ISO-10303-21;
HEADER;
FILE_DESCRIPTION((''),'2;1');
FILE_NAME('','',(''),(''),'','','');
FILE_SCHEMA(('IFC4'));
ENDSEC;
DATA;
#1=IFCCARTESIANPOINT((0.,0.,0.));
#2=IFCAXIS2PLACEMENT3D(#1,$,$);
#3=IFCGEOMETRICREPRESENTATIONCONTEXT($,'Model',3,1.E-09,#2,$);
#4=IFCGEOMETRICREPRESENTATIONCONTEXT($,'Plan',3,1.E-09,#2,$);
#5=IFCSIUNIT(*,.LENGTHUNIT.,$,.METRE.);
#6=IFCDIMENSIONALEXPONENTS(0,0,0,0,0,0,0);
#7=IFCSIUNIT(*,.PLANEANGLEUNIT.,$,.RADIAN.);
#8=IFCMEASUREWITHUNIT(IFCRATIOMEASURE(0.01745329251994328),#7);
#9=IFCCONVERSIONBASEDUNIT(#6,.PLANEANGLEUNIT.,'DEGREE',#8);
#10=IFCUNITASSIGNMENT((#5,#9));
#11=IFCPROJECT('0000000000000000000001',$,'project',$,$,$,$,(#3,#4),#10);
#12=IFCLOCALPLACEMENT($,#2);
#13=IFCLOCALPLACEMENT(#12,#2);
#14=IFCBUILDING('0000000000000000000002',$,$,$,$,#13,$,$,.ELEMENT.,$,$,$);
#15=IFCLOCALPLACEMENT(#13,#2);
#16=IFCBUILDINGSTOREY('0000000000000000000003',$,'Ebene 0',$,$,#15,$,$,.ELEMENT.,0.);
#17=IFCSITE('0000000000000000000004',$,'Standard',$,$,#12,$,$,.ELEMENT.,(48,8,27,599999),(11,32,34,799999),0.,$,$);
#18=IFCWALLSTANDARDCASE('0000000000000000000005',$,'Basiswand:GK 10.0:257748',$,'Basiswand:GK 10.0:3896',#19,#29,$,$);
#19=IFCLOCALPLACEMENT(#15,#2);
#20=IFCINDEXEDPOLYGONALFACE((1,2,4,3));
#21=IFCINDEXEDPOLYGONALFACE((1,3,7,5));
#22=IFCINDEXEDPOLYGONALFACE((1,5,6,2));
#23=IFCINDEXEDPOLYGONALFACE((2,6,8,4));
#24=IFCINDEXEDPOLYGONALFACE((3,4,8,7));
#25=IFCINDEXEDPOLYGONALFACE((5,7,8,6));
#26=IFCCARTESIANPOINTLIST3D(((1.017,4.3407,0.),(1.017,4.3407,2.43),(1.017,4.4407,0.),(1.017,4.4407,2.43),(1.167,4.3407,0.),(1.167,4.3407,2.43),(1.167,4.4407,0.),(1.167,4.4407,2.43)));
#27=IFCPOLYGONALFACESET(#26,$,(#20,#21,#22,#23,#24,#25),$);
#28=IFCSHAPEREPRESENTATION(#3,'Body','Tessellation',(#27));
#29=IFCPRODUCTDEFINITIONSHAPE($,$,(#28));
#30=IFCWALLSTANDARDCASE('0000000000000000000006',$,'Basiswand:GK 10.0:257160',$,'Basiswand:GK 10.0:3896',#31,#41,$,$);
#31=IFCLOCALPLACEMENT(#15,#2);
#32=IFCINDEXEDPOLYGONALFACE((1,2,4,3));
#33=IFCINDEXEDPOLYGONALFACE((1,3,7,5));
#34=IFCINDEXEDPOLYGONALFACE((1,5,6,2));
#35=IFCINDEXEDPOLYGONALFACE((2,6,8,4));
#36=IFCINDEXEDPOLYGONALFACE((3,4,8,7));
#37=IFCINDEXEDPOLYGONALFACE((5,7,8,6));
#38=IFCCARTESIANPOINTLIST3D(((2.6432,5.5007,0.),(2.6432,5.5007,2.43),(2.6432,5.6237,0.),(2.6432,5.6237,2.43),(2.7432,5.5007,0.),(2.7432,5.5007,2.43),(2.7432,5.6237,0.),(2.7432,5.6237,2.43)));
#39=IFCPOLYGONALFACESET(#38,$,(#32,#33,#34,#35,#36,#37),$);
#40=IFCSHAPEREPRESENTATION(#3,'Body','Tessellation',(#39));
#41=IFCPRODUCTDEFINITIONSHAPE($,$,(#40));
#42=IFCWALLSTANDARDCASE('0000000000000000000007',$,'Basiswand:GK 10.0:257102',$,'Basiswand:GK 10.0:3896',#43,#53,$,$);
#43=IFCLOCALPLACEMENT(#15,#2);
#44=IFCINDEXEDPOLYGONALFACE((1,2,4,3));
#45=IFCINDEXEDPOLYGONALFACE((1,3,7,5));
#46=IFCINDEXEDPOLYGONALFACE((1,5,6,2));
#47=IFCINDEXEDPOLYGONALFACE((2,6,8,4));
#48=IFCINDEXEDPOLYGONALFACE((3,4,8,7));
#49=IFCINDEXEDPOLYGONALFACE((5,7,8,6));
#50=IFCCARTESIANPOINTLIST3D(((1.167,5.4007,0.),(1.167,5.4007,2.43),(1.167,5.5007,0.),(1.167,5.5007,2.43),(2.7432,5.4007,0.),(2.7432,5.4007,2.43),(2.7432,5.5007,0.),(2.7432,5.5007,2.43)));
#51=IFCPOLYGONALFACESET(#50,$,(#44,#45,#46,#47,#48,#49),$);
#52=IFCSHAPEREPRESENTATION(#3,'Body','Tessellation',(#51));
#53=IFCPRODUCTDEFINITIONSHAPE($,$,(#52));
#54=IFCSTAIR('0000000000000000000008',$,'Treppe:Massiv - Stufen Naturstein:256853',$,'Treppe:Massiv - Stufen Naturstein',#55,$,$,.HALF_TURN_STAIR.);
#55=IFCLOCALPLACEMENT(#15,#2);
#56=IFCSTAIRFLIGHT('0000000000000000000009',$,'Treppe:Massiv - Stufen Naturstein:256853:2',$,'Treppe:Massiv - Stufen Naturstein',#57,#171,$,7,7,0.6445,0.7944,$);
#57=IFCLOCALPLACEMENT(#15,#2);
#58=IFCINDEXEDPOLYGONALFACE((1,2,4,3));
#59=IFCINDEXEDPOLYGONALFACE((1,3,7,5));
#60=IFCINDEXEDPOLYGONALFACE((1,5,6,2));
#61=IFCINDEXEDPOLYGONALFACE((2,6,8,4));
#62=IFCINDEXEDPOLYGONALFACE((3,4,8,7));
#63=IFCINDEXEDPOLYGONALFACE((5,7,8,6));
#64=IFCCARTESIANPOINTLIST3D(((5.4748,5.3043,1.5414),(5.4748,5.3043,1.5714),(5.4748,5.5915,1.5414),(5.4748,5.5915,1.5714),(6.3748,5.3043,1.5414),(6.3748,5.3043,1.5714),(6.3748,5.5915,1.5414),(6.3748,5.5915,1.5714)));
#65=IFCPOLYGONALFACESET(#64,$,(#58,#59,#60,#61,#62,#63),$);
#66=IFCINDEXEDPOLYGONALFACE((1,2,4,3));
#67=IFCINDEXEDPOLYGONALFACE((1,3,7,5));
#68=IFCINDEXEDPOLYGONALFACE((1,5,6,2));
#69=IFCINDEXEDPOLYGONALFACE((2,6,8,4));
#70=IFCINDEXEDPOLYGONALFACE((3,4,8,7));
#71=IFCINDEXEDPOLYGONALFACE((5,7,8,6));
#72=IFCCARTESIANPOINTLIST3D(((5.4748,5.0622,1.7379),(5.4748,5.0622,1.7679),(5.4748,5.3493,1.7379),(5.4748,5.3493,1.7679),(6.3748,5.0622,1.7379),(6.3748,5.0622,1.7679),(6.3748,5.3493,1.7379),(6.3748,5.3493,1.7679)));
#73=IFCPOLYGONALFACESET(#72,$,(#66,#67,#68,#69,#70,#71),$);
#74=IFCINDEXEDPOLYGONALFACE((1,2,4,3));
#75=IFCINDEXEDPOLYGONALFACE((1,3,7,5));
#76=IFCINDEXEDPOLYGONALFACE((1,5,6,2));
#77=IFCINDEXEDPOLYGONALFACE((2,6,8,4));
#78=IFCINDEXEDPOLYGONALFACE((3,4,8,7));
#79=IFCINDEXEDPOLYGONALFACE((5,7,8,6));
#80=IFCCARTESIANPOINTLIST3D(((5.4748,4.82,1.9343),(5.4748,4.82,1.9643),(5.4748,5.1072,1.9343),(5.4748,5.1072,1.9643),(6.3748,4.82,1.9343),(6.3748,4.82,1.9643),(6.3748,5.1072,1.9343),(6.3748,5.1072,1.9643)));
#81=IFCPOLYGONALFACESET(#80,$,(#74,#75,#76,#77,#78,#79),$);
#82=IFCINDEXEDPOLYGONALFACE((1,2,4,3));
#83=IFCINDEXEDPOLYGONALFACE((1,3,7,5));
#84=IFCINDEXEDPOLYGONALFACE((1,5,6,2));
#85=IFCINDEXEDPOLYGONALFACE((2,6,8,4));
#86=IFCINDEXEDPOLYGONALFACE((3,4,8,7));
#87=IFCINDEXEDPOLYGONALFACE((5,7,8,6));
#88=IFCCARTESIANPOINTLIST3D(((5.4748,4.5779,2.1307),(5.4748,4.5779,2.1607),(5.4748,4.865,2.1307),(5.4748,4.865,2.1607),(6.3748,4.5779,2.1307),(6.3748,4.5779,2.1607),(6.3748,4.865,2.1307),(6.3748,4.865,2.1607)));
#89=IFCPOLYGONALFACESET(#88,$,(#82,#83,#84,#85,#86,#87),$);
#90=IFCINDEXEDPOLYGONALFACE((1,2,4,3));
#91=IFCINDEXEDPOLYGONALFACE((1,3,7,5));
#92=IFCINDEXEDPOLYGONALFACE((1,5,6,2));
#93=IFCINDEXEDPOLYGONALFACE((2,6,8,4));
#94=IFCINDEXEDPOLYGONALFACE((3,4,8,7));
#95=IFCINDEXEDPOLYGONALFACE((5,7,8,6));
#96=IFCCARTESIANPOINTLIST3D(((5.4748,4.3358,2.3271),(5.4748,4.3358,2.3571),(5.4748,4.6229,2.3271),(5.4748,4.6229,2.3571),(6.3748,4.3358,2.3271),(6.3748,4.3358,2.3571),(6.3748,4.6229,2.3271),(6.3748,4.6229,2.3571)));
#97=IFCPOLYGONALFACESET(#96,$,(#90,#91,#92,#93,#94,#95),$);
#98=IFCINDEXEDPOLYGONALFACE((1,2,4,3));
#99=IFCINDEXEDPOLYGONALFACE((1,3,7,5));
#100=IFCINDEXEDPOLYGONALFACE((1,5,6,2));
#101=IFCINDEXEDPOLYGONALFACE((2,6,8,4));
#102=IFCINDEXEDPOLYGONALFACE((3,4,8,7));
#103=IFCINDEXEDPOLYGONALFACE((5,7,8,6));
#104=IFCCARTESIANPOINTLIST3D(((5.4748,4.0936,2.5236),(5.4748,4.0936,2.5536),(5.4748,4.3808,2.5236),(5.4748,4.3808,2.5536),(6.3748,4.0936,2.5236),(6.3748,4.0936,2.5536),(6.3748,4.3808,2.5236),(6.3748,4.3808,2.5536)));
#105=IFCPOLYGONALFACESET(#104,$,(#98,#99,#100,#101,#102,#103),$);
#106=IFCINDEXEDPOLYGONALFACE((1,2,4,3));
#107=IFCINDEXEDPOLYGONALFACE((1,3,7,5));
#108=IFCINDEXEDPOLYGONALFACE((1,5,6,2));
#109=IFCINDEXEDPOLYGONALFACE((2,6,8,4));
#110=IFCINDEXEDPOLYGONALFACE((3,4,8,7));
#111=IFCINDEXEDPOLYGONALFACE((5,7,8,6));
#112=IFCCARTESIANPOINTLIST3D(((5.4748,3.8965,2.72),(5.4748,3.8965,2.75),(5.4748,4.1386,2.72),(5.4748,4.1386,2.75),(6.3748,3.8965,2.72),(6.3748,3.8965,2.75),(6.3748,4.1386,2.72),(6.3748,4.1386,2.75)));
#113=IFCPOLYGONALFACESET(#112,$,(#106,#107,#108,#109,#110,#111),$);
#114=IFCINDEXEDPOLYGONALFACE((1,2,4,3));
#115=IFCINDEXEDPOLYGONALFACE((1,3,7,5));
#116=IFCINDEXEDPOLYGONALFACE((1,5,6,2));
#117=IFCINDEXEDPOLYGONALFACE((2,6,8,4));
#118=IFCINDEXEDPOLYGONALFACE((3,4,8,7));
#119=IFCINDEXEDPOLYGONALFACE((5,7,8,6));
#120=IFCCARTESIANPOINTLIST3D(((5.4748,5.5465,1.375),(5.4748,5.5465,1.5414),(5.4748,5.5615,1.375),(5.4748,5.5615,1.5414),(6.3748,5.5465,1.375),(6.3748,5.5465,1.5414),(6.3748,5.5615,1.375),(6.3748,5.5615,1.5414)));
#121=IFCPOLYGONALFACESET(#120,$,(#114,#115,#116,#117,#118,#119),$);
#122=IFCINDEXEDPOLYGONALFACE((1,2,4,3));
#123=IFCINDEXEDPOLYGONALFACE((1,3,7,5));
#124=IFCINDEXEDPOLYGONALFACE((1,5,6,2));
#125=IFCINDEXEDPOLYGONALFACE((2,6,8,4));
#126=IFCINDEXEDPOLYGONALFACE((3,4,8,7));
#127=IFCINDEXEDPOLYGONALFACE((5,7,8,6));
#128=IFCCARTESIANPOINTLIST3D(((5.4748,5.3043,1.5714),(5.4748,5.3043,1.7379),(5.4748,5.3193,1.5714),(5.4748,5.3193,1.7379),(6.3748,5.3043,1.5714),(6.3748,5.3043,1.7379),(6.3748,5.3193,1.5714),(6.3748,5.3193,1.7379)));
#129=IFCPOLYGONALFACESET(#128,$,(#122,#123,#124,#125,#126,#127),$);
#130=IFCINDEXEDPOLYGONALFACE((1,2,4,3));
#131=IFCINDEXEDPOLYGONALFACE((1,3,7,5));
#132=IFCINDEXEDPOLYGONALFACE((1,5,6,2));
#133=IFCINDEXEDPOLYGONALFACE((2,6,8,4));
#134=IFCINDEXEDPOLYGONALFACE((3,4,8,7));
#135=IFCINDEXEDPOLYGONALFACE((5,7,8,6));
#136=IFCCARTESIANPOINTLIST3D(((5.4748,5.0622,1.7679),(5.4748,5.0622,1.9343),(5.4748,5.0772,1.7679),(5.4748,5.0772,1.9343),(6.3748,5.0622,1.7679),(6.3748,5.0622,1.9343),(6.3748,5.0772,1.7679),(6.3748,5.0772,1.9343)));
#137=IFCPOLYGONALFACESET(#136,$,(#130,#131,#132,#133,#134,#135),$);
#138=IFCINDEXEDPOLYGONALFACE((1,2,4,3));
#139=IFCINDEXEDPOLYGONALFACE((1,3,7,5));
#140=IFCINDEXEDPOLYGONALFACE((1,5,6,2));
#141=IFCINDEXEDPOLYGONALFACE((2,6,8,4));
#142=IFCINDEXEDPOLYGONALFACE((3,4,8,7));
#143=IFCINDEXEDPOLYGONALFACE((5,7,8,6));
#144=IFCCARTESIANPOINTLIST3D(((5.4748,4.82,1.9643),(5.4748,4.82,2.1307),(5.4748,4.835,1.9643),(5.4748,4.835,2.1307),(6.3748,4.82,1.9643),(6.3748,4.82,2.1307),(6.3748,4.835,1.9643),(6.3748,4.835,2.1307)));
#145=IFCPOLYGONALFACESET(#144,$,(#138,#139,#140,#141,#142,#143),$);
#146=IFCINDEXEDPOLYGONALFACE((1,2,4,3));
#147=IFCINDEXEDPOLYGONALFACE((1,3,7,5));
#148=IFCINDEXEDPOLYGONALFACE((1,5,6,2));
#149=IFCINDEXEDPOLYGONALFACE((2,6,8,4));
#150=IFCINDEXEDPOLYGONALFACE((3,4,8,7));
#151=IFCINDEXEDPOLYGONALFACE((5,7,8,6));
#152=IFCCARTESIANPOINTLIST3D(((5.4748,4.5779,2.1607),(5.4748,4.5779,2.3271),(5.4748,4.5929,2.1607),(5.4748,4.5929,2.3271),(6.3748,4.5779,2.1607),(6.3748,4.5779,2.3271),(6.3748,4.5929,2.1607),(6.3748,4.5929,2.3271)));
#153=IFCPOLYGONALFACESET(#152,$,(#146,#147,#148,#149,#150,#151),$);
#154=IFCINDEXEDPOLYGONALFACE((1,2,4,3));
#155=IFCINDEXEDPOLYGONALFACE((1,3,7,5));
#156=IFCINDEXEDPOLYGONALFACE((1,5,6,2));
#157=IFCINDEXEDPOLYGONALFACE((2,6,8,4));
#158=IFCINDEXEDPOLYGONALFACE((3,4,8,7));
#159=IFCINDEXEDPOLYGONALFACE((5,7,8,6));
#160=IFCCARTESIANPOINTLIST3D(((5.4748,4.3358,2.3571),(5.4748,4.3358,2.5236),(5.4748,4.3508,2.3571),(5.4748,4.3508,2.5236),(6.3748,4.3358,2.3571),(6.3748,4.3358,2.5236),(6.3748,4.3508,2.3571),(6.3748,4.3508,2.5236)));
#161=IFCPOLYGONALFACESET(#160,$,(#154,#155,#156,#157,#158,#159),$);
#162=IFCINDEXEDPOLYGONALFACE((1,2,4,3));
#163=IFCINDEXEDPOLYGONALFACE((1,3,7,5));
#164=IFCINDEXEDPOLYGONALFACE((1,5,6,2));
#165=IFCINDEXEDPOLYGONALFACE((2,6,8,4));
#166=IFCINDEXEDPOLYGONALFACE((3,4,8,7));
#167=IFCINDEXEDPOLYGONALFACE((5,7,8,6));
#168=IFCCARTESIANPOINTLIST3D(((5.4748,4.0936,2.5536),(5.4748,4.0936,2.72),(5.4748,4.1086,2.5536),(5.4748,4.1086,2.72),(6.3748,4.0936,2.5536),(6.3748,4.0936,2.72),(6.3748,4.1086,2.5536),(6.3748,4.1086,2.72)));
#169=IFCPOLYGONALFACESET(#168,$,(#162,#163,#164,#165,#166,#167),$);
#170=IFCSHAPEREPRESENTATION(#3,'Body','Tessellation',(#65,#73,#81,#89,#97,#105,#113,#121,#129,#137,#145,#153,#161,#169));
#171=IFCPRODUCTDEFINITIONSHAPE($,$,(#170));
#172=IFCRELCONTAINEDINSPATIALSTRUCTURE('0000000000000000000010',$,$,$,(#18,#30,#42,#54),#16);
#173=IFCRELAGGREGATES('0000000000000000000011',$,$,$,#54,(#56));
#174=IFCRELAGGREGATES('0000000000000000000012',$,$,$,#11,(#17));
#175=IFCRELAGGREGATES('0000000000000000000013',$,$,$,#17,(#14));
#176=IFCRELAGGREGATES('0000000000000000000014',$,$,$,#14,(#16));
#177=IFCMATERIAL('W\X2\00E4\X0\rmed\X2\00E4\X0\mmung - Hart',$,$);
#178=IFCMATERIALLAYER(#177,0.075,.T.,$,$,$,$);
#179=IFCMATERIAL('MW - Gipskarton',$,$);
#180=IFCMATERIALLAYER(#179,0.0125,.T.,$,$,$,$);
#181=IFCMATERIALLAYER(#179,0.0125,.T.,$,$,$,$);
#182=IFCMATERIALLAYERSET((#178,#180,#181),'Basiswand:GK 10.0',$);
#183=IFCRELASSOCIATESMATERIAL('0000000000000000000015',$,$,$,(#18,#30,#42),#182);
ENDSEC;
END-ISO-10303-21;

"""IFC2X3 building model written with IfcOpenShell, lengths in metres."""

from ifc_helpers import new_model, entity, si_unit, converted_unit, frame, frame_2d, origin, origin_2d_with_axis, place, context, project, spatial, polyline, rectangle, extrude, clip, bounded_halfspace, material, layer, layer_set, layer_usage, element, aggregate, save


model = new_model("IFC2X3")

# Units and contexts
plan_context = context("Plan", 3, precision=1e-09, world=origin())
model_context = context("Model", 3, precision=1e-09, world=origin())
ifc_project = project(units=[si_unit("LENGTHUNIT", "METRE"), converted_unit("PLANEANGLEUNIT", "DEGREE", entity("IfcRatioMeasure", 0.01745329251994328), si_unit("PLANEANGLEUNIT", "RADIAN"), dimensions=[0, 0, 0, 0, 0, 0, 0])], contexts=[model_context, plan_context])

# Site, building, storey
site_placement = place(None, origin())
site = spatial("IfcSite", under=ifc_project, at=site_placement, Name="Standard", CompositionType="ELEMENT", RefLatitude=(48, 8, 27, 599999), RefLongitude=(11, 32, 34, 799999), RefElevation=0.0)
building_placement = place(site_placement, origin())
building = spatial("IfcBuilding", under=site, at=building_placement, CompositionType="ELEMENT")
storey_placement = place(building_placement, origin())
storey = spatial("IfcBuildingStorey", under=building, at=storey_placement, Name="Ebene 0", CompositionType="ELEMENT", Elevation=0.0)

# Shared definitions
ifc_material_1 = material(Name="Wärmedämmung - Hart")

# Walls
ifc_layer_1 = layer(ifc_material_1, 0.075, ventilated=True)
ifc_material_2 = material(Name="MW - Gipskarton")
ifc_layer_2 = layer(ifc_material_2, 0.0125, ventilated=True)
ifc_layer_3 = layer(ifc_material_2, 0.0125, ventilated=True)
ifc_layer_set_1 = layer_set([ifc_layer_1, ifc_layer_2, ifc_layer_3], Name="Basiswand:GK 10.0")
ifc_layer_usage_1 = layer_usage(ifc_layer_set_1, "AXIS2", "NEGATIVE", 0.05)
wall_1_placement = place(storey_placement, frame((1.167, 4.3907, 0.0), z_axis=(0.0, 0.0, 1.0), x_axis=(-1.0, 0.0, 0.0)))
element("IfcWallStandardCase", 1, at=wall_1_placement, inside=storey, material=ifc_layer_usage_1, Name="Basiswand:GK 10.0:257748", ObjectType="Basiswand:GK 10.0:3896", context=model_context, shape_type="Clipping", body=[
    clip(extrude(rectangle(XDim=0.15, YDim=0.1, at=frame_2d((0.075, 0.0), x_axis=(-1.0, 0.0))), origin(), (0.0, 0.0, 1.0), 2.43), bounded_halfspace(frame((0.0, -0.05, 2.43), z_axis=(0.0, 0.0, -1.0), x_axis=(0.0, -1.0, 0.0)), True, frame((0.0, -0.05, 2.43)), polyline([(0.0, 0.0), (0.1, 0.0), (0.15, 0.0), (0.15, 0.1), (0.0, 0.1), (0.0, 0.0)]))),
])
ifc_layer_usage_2 = layer_usage(ifc_layer_set_1, "AXIS2", "NEGATIVE", 0.05)
wall_2_placement = place(storey_placement, frame((2.6932, 5.5007, 0.0), z_axis=(0.0, 0.0, 1.0), x_axis=(0.0, 1.0, 0.0)))
element("IfcWallStandardCase", 2, at=wall_2_placement, inside=storey, material=ifc_layer_usage_2, Name="Basiswand:GK 10.0:257160", ObjectType="Basiswand:GK 10.0:3896", context=model_context, shape_type="Clipping", body=[
    clip(extrude(rectangle(XDim=0.123, YDim=0.1, at=frame_2d((0.0615, 0.0), x_axis=(-1.0, 0.0))), origin(), (0.0, 0.0, 1.0), 2.43), bounded_halfspace(frame((0.0, -0.05, 2.43), z_axis=(0.0, 0.0, -1.0), x_axis=(1.0, 0.0, 0.0)), True, frame((0.0, -0.05, 2.43)), polyline([(0.0, 0.0), (0.123, 0.0), (0.123, 0.1), (0.0, 0.1), (0.0, 0.0)]))),
])

# Wall
ifc_layer_usage_3 = layer_usage(ifc_layer_set_1, "AXIS2", "NEGATIVE", 0.05)
wall_3_placement = place(storey_placement, frame((1.167, 5.4507, 0.0)))
element("IfcWallStandardCase", 3, at=wall_3_placement, inside=storey, material=ifc_layer_usage_3, Name="Basiswand:GK 10.0:257102", ObjectType="Basiswand:GK 10.0:3896", context=model_context, shape_type="Clipping", body=[
    clip(extrude(rectangle(XDim=1.5762, YDim=0.1, at=frame_2d((0.7881, 0.0), x_axis=(-1.0, 0.0))), origin(), (0.0, 0.0, 1.0), 2.43), bounded_halfspace(frame((0.0, -0.05, 2.43), z_axis=(0.0, 0.0, -1.0), x_axis=(0.0, 1.0, 0.0)), True, frame((0.0, -0.05, 2.43)), polyline([(0.0, 0.0), (1.5762, 0.0), (1.5762, 0.1), (1.4762, 0.1), (0.0, 0.1), (0.0, 0.0)]))),
])

# Stair, stair flight
stair_placement = place(storey_placement, origin())
stair = element("IfcStair", 4, at=stair_placement, inside=storey, Name="Treppe:Massiv - Stufen Naturstein:256853", ObjectType="Treppe:Massiv - Stufen Naturstein", ShapeType="HALF_TURN_STAIR")
stair_flight_1_placement = place(storey_placement, origin())
stair_flight_1 = element("IfcStairFlight", 5, at=stair_flight_1_placement, Name="Treppe:Massiv - Stufen Naturstein:256853:2", ObjectType="Treppe:Massiv - Stufen Naturstein", NumberOfRiser=7, NumberOfTreads=7, RiserHeight=0.6445, TreadLength=0.7944, context=model_context, shape_type="SweptSolid", body=[
    extrude(rectangle(XDim=0.2871, YDim=0.9, at=origin_2d_with_axis()), frame((5.9248, 5.4479, 1.5414), z_axis=(0.0, 0.0, 1.0), x_axis=(0.0, 1.0, 0.0)), (0.0, 0.0, 1.0), 0.03),
    extrude(rectangle(XDim=0.2871, YDim=0.9, at=origin_2d_with_axis()), frame((5.9248, 5.2058, 1.7379), z_axis=(0.0, 0.0, 1.0), x_axis=(0.0, 1.0, 0.0)), (0.0, 0.0, 1.0), 0.03),
    extrude(rectangle(XDim=0.2871, YDim=0.9, at=origin_2d_with_axis()), frame((5.9248, 4.9636, 1.9343), z_axis=(0.0, 0.0, 1.0), x_axis=(0.0, 1.0, 0.0)), (0.0, 0.0, 1.0), 0.03),
    extrude(rectangle(XDim=0.2871, YDim=0.9, at=origin_2d_with_axis()), frame((5.9248, 4.7215, 2.1307), z_axis=(0.0, 0.0, 1.0), x_axis=(0.0, 1.0, 0.0)), (0.0, 0.0, 1.0), 0.03),
    extrude(rectangle(XDim=0.2871, YDim=0.9, at=origin_2d_with_axis()), frame((5.9248, 4.4793, 2.3271), z_axis=(0.0, 0.0, 1.0), x_axis=(0.0, 1.0, 0.0)), (0.0, 0.0, 1.0), 0.03),
    extrude(rectangle(XDim=0.2871, YDim=0.9, at=origin_2d_with_axis()), frame((5.9248, 4.2372, 2.5236), z_axis=(0.0, 0.0, 1.0), x_axis=(0.0, 1.0, 0.0)), (0.0, 0.0, 1.0), 0.03),
    extrude(rectangle(XDim=0.2421, YDim=0.9, at=origin_2d_with_axis()), frame((5.9248, 4.0175, 2.72), z_axis=(0.0, 0.0, 1.0), x_axis=(0.0, 1.0, 0.0)), (0.0, 0.0, 1.0), 0.03),
    extrude(rectangle(XDim=0.9, YDim=0.015, at=origin_2d_with_axis()), frame((5.9248, 5.554, 1.375)), (0.0, 0.0, 1.0), 0.1664),
    extrude(rectangle(XDim=0.9, YDim=0.015, at=origin_2d_with_axis()), frame((5.9248, 5.3118, 1.5714)), (0.0, 0.0, 1.0), 0.1664),
    extrude(rectangle(XDim=0.9, YDim=0.015, at=origin_2d_with_axis()), frame((5.9248, 5.0697, 1.7679)), (0.0, 0.0, 1.0), 0.1664),
    extrude(rectangle(XDim=0.9, YDim=0.015, at=origin_2d_with_axis()), frame((5.9248, 4.8275, 1.9643)), (0.0, 0.0, 1.0), 0.1664),
    extrude(rectangle(XDim=0.9, YDim=0.015, at=origin_2d_with_axis()), frame((5.9248, 4.5854, 2.1607)), (0.0, 0.0, 1.0), 0.1664),
    extrude(rectangle(XDim=0.9, YDim=0.015, at=origin_2d_with_axis()), frame((5.9248, 4.3433, 2.3571)), (0.0, 0.0, 1.0), 0.1664),
    extrude(rectangle(XDim=0.9, YDim=0.015, at=origin_2d_with_axis()), frame((5.9248, 4.1011, 2.5536)), (0.0, 0.0, 1.0), 0.1664),
])
aggregate(stair, [stair_flight_1])

save(model, "model.ifc")
